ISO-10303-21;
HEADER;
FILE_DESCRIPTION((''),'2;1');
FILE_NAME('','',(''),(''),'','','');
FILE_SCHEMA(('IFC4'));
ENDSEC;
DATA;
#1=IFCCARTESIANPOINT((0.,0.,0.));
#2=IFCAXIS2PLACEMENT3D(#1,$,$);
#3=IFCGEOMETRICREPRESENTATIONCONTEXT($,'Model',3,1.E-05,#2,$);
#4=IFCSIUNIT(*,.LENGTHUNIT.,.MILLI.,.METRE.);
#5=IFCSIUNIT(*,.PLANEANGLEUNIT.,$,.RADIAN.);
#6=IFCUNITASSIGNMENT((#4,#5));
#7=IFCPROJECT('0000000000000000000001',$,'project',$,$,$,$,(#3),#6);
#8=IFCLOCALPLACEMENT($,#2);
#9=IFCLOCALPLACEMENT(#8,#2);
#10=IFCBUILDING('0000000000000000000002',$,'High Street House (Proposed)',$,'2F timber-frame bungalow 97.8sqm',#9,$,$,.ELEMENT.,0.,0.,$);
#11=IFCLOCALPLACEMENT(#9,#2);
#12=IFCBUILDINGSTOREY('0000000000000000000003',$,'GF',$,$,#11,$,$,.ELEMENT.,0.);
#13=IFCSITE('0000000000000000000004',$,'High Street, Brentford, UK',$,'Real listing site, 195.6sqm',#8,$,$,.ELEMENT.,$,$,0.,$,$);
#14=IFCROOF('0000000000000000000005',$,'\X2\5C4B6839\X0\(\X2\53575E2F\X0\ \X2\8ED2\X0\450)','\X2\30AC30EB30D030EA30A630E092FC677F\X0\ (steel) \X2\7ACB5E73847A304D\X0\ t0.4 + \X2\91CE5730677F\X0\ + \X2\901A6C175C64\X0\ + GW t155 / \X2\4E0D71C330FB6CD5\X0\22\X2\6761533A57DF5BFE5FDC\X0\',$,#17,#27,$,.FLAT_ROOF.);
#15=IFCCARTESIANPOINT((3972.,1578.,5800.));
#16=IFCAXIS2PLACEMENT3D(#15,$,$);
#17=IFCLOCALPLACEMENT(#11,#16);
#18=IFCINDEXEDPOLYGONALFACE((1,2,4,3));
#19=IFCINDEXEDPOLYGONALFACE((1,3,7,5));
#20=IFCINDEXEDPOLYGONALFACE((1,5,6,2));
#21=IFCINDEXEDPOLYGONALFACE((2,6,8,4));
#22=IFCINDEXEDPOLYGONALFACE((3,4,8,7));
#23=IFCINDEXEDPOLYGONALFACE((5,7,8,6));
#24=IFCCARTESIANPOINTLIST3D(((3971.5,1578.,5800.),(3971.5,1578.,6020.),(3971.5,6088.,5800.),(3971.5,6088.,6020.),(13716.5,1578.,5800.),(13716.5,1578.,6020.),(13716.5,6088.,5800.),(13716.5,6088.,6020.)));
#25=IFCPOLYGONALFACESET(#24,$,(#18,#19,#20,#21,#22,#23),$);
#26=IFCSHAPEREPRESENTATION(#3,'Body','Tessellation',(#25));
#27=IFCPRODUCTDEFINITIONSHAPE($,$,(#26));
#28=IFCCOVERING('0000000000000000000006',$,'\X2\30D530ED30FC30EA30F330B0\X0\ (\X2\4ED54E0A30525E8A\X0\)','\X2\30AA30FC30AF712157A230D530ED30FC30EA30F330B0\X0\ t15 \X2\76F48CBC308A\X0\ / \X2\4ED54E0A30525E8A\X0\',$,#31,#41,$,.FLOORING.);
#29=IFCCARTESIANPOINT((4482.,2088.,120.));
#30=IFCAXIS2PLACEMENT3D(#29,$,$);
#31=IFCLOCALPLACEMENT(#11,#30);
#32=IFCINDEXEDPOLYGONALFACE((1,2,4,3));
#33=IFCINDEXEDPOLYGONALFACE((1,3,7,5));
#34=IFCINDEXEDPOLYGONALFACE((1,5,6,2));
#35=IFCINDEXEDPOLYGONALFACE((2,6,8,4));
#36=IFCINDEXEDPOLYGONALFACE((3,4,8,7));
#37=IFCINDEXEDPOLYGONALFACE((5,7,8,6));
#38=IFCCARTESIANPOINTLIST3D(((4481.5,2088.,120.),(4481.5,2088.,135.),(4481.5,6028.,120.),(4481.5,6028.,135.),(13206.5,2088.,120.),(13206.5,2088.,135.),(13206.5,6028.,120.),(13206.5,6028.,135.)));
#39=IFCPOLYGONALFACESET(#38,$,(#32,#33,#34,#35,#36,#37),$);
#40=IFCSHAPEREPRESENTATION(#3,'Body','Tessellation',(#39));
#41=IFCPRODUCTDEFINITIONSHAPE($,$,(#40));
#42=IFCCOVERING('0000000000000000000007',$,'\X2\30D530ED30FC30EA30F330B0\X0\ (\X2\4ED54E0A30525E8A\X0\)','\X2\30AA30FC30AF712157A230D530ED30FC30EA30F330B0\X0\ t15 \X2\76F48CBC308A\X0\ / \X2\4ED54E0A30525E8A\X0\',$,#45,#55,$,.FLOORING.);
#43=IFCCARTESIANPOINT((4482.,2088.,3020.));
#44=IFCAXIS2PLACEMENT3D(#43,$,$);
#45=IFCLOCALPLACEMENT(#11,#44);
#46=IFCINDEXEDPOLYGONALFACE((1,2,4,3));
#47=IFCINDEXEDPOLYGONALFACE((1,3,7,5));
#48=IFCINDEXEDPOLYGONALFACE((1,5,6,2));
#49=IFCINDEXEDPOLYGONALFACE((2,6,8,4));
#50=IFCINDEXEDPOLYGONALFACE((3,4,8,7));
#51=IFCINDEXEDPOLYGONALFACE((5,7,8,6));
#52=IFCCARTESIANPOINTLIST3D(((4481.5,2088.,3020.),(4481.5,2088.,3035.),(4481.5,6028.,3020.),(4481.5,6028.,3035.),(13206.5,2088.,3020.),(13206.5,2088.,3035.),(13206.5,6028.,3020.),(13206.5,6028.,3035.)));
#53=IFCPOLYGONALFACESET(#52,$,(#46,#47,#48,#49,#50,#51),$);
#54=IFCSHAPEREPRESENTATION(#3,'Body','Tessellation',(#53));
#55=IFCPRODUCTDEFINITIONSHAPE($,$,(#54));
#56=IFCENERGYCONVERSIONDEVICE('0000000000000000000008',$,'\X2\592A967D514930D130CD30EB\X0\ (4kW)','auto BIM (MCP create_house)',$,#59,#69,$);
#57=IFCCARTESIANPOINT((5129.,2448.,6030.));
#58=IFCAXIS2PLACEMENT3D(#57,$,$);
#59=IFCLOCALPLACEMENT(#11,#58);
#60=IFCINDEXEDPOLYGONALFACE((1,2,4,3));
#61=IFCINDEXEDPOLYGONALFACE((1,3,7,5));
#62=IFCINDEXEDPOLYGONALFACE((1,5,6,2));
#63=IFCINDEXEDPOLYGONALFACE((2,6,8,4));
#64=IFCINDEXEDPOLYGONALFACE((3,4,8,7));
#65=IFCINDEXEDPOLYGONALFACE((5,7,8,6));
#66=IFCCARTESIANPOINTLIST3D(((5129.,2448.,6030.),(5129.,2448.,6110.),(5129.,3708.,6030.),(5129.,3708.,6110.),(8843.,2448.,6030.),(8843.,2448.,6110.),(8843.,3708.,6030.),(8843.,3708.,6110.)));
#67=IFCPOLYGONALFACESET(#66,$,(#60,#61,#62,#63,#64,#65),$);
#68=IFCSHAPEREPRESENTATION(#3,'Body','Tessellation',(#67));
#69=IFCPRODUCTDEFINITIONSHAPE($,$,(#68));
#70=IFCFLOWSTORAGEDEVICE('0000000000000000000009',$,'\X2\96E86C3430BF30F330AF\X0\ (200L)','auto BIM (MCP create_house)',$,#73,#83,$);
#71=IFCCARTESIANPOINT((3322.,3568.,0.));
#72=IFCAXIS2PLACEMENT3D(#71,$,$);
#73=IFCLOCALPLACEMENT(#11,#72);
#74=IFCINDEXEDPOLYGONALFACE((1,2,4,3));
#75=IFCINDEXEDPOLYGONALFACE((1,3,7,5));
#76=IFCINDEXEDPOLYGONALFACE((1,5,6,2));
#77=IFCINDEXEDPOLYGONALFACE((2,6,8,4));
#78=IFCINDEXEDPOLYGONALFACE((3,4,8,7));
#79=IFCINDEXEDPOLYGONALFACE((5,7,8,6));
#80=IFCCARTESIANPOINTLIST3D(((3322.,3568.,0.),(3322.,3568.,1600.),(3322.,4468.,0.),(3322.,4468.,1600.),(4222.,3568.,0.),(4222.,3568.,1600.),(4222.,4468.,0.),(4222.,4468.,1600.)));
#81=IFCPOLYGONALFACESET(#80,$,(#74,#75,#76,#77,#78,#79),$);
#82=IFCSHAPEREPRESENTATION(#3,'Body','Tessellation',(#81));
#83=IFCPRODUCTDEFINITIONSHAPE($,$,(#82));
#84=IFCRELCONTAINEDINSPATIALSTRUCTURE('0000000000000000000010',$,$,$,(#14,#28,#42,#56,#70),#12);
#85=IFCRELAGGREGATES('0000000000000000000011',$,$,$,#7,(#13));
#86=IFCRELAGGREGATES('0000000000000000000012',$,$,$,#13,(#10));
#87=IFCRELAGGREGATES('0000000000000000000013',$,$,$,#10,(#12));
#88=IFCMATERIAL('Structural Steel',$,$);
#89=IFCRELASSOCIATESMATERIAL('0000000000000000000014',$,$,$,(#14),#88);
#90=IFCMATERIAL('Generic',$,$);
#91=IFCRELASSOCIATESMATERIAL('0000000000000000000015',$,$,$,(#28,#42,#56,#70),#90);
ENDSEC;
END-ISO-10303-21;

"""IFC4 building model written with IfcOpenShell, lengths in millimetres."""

from ifc_helpers import new_model, si_unit, frame, frame_2d, origin, place, context, project, spatial, rectangle, extrude, material, element, save


model = new_model("IFC4")

# Units and contexts
model_context = context("Model", 3, precision=1e-05, world=origin())
ifc_project = project(units=[si_unit("LENGTHUNIT", "METRE", prefix="MILLI"), si_unit("PLANEANGLEUNIT", "RADIAN")], contexts=[model_context])

# Site, building, storey
site_placement = place(None, origin())
site = spatial("IfcSite", under=ifc_project, at=site_placement, Name="High Street, Brentford, UK", ObjectType="Real listing site, 195.6sqm", CompositionType="ELEMENT", RefElevation=0.0)
building_placement = place(site_placement, origin())
building = spatial("IfcBuilding", under=site, at=building_placement, Name="High Street House (Proposed)", ObjectType="2F timber-frame bungalow 97.8sqm", CompositionType="ELEMENT", ElevationOfRefHeight=0.0, ElevationOfTerrain=0.0)
storey_placement = place(building_placement, origin())
storey = spatial("IfcBuildingStorey", under=building, at=storey_placement, Name="GF", CompositionType="ELEMENT", Elevation=0.0)

# Roof
ifc_material_1 = material(Name="Structural Steel")
for number, where, name in (
    (1, (3972.0, 1578.0, 5800.0), "屋根(南帯 軒450)"),
):
    element("IfcRoof", number, at=place(storey_placement, frame(where)), inside=storey, material=ifc_material_1, Name=name, Description="ガルバリウム鋼板 (steel) 立平葺き t0.4 + 野地板 + 通気層 + GW t155 / 不燃・法22条区域対応", PredefinedType="FLAT_ROOF", context=model_context, shape_type="SweptSolid", body=[
        extrude(rectangle(XDim=9745.0, YDim=4510.0, at=frame_2d((4872.0, 2255.0))), frame((3972.0, 1578.0, 5800.0)), (0.0, 0.0, 1.0), 220.0),
    ])

# Coverings
ifc_material_2 = material(Name="Generic")
covering_1_placement = place(storey_placement, frame((4482.0, 2088.0, 120.0)))
element("IfcCovering", 2, at=covering_1_placement, inside=storey, material=ifc_material_2, Name="フローリング (仕上げ床)", Description="オーク無垢フローリング t15 直貼り / 仕上げ床", PredefinedType="FLOORING", context=model_context, shape_type="SweptSolid", body=[
    extrude(rectangle(XDim=8725.0, YDim=3940.0, at=frame_2d((4362.0, 1970.0))), frame((4482.0, 2088.0, 120.0)), (0.0, 0.0, 1.0), 15.0),
])
covering_2_placement = place(storey_placement, frame((4482.0, 2088.0, 3020.0)))
element("IfcCovering", 3, at=covering_2_placement, inside=storey, material=ifc_material_2, Name="フローリング (仕上げ床)", Description="オーク無垢フローリング t15 直貼り / 仕上げ床", PredefinedType="FLOORING", context=model_context, shape_type="SweptSolid", body=[
    extrude(rectangle(XDim=8725.0, YDim=3940.0, at=frame_2d((4362.0, 1970.0))), frame((4482.0, 2088.0, 3020.0)), (0.0, 0.0, 1.0), 15.0),
])

# Energy conversion device
energy_conversion_device_placement = place(storey_placement, frame((5129.0, 2448.0, 6030.0)))
element("IfcEnergyConversionDevice", 4, at=energy_conversion_device_placement, inside=storey, material=ifc_material_2, Name="太陽光パネル (4kW)", Description="auto BIM (MCP create_house)", context=model_context, shape_type="SweptSolid", body=[
    extrude(rectangle(XDim=3714.0, YDim=1260.0, at=frame_2d((1857.0, 630.0))), frame((5129.0, 2448.0, 6030.0)), (0.0, 0.0, 1.0), 80.0),
])

# Flow storage device
flow_storage_device_placement = place(storey_placement, frame((3322.0, 3568.0, 0.0)))
element("IfcFlowStorageDevice", 5, at=flow_storage_device_placement, inside=storey, material=ifc_material_2, Name="雨水タンク (200L)", Description="auto BIM (MCP create_house)", context=model_context, shape_type="SweptSolid", body=[
    extrude(rectangle(XDim=900.0, YDim=900.0, at=frame_2d((450.0, 450.0))), frame((3322.0, 3568.0, 0.0)), (0.0, 0.0, 1.0), 1600.0),
])

save(model, "model.ifc")
